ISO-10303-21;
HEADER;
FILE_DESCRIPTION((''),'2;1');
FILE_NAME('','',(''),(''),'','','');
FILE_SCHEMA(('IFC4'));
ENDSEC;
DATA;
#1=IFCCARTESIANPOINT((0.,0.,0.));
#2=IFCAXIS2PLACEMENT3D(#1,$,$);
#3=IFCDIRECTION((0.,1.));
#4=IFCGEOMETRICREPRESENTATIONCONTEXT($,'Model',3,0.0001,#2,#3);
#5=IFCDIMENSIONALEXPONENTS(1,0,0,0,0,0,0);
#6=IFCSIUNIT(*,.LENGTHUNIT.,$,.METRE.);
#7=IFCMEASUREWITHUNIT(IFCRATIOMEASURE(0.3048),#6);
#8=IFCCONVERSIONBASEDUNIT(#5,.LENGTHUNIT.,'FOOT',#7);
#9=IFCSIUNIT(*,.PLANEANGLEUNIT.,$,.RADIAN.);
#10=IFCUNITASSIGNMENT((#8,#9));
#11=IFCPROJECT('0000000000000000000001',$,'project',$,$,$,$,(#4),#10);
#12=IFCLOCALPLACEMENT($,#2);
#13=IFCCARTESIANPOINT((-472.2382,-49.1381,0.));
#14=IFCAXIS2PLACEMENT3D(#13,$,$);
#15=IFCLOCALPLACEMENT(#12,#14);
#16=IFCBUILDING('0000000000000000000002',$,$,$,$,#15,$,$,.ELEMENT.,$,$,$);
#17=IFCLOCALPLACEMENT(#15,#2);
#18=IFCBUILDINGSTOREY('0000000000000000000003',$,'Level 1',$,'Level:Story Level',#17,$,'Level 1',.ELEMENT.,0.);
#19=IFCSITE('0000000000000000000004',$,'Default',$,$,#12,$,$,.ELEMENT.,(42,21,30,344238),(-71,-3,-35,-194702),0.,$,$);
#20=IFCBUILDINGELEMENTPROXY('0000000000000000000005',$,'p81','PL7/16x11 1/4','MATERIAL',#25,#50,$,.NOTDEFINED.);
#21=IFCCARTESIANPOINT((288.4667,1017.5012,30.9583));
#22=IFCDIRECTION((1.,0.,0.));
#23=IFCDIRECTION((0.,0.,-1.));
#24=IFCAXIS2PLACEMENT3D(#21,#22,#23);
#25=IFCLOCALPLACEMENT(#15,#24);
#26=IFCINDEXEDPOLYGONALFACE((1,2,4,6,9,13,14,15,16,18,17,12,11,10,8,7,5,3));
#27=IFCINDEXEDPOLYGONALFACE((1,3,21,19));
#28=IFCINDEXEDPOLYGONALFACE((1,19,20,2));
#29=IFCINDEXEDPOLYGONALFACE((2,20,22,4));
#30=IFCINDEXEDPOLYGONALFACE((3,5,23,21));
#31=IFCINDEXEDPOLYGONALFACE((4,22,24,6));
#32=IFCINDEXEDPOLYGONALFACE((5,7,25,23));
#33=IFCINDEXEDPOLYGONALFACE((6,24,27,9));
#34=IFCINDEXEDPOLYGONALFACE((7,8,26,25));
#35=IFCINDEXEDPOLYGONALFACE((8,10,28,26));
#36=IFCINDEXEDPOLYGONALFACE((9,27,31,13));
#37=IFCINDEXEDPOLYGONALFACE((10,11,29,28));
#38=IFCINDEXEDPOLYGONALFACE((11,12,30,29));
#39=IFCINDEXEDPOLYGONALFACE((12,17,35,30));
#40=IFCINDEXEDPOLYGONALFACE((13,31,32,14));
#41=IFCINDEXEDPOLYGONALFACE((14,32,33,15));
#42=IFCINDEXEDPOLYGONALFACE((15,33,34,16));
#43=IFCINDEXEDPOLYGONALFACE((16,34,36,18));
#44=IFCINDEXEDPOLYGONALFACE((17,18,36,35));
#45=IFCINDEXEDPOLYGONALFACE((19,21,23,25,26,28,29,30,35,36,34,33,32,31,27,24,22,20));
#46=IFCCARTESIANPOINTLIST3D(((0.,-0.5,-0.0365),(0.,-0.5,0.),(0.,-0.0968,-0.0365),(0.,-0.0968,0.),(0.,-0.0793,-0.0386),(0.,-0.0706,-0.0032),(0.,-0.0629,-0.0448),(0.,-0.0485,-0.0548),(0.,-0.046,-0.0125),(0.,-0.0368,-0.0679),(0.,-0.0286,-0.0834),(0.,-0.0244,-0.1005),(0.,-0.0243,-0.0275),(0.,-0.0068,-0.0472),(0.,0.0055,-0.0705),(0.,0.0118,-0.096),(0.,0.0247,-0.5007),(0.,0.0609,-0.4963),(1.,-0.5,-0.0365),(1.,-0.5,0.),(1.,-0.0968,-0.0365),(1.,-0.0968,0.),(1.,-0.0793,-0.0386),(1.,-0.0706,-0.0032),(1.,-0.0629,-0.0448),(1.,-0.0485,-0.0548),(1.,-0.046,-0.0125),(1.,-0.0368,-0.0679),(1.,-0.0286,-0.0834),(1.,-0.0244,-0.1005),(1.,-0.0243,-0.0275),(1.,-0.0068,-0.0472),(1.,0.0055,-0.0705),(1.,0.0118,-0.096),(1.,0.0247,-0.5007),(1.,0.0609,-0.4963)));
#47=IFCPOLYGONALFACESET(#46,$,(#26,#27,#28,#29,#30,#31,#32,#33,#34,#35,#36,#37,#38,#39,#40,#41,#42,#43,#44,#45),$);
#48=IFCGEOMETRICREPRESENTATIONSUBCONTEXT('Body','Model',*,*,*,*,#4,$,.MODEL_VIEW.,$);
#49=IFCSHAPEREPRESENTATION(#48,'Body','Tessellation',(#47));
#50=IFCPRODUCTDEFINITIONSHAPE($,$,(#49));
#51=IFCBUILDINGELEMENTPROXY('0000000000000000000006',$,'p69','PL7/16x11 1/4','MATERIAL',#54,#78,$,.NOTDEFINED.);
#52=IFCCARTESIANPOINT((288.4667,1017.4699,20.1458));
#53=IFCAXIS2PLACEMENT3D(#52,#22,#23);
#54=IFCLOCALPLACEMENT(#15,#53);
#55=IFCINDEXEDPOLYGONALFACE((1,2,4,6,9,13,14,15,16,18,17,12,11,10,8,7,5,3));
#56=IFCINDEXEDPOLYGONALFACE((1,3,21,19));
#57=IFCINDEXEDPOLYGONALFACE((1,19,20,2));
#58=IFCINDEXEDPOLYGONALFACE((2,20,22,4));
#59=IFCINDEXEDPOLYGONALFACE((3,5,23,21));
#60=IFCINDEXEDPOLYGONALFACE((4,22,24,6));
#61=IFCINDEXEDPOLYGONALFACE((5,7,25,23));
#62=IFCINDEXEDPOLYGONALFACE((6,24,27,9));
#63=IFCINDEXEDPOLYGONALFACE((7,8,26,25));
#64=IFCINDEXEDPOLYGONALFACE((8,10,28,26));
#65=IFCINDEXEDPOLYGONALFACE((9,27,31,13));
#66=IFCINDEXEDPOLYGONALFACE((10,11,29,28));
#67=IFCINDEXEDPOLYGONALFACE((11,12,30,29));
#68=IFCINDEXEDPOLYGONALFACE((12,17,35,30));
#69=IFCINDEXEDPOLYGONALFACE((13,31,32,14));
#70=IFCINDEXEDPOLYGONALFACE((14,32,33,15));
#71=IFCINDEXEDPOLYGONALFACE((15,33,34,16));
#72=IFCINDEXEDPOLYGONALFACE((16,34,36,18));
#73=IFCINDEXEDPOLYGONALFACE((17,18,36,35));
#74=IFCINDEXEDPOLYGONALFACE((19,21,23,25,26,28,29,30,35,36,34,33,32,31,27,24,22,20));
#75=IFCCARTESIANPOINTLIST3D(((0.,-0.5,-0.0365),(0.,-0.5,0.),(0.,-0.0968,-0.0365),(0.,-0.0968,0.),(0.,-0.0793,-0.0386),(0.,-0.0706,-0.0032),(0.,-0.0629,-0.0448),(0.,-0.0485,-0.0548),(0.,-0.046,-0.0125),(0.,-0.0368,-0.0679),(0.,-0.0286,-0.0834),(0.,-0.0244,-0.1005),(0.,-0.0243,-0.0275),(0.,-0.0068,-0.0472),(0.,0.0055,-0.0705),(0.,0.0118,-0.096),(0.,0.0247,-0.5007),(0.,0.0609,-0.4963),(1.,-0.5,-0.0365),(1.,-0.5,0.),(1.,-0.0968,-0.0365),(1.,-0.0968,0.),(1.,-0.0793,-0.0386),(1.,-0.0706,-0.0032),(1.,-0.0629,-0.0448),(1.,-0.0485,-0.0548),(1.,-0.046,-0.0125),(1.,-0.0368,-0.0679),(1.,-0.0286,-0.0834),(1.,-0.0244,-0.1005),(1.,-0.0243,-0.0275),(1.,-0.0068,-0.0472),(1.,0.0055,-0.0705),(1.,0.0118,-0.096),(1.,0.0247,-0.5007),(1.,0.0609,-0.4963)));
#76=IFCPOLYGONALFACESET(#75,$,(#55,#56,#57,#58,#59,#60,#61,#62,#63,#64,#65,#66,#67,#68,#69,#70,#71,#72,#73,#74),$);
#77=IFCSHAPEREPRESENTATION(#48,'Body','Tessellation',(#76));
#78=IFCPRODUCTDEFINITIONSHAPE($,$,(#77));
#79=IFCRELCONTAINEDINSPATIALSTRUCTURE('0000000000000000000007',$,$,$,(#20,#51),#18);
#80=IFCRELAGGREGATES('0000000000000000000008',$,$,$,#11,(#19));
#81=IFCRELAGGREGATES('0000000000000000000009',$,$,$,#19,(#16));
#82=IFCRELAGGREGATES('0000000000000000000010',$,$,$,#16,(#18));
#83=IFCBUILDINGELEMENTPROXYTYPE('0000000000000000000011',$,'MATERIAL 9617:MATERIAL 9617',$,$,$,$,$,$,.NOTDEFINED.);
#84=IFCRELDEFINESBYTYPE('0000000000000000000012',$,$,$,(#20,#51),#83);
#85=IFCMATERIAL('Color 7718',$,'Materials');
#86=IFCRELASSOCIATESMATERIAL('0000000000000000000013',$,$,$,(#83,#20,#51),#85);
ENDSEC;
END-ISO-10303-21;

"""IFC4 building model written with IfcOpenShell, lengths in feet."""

from ifc_helpers import new_model, entity, si_unit, converted_unit, direction, frame, origin, place, context, subcontext, project, spatial, polyline, outline, extrude, source, transform, mapped, material, type_object, type_shapes, element, save


model = new_model("IFC4")

# Units and contexts
model_context = context("Model", 3, precision=0.0001, world=origin(), true_north=direction((0.0, 1.0)))
body_context = subcontext(model_context, "Body", "Model", "MODEL_VIEW")
ifc_project = project(units=[converted_unit("LENGTHUNIT", "FOOT", entity("IfcRatioMeasure", 0.3048), si_unit("LENGTHUNIT", "METRE"), dimensions=[1, 0, 0, 0, 0, 0, 0]), si_unit("PLANEANGLEUNIT", "RADIAN")], contexts=[model_context])

# Site, building, storey
site_placement = place(None, origin())
site = spatial("IfcSite", under=ifc_project, at=site_placement, Name="Default", CompositionType="ELEMENT", RefLatitude=(42, 21, 30, 344238), RefLongitude=(-71, -3, -35, -194702), RefElevation=0.0)
building_placement = place(site_placement, frame((-472.2382, -49.1381, 0.0)))
building = spatial("IfcBuilding", under=site, at=building_placement, CompositionType="ELEMENT")
storey_placement = place(building_placement, origin())
storey = spatial("IfcBuildingStorey", under=building, at=storey_placement, Name="Level 1", ObjectType="Level:Story Level", LongName="Level 1", CompositionType="ELEMENT", Elevation=0.0)

# Building element proxies
ifc_material_1 = material(Name="Color 7718", Category="Materials")
building_element_proxy_type_1 = type_object("IfcBuildingElementProxyType", Name="MATERIAL 9617:MATERIAL 9617", PredefinedType="NOTDEFINED", material=ifc_material_1)
shared_shape_1 = source(origin(), body_context, "Body", "SweptSolid", [
    extrude(outline(polyline([(0.0124, -0.0954), (0.4156, -0.0954), (0.4156, -0.0589), (0.0124, -0.0589), (-0.005, -0.0568), (-0.0215, -0.0506), (-0.0359, -0.0406), (-0.0476, -0.0275), (-0.0558, -0.0119), (-0.06, 0.0051), (-0.1091, 0.4053), (-0.1453, 0.4009), (-0.0962, 0.0007), (-0.0898, -0.0249), (-0.0776, -0.0482), (-0.0601, -0.0679), (-0.0384, -0.0829), (-0.0138, -0.0922), (0.0124, -0.0954)])), frame((0.0, -0.0844, -0.0954), z_axis=(1.0, 0.0, 0.0), x_axis=(0.0, -1.0, 0.0)), (0.0, 0.0, 1.0), 1.0),
])
type_shapes(building_element_proxy_type_1, [shared_shape_1])
for number, where, z_axis, x_axis, name in (
    (1, (288.4667, 1017.5012, 30.9583), (1.0, 0.0, 0.0), (0.0, 0.0, -1.0), "p81"),
    (2, (288.4667, 1017.4699, 20.1458), (1.0, 0.0, 0.0), (0.0, 0.0, -1.0), "p69"),
):
    element("IfcBuildingElementProxy", number, at=place(building_placement, frame(where, z_axis=z_axis, x_axis=x_axis)), inside=storey, type_object=building_element_proxy_type_1, material=ifc_material_1, Name=name, Description="PL7/16x11 1/4", ObjectType="MATERIAL", PredefinedType="NOTDEFINED", context=body_context, shape_type="MappedRepresentation", body=[
        mapped(shared_shape_1, transform((0.0, 0.0, 0.0), scale=1.0)),
    ])

save(model, "model.ifc")
